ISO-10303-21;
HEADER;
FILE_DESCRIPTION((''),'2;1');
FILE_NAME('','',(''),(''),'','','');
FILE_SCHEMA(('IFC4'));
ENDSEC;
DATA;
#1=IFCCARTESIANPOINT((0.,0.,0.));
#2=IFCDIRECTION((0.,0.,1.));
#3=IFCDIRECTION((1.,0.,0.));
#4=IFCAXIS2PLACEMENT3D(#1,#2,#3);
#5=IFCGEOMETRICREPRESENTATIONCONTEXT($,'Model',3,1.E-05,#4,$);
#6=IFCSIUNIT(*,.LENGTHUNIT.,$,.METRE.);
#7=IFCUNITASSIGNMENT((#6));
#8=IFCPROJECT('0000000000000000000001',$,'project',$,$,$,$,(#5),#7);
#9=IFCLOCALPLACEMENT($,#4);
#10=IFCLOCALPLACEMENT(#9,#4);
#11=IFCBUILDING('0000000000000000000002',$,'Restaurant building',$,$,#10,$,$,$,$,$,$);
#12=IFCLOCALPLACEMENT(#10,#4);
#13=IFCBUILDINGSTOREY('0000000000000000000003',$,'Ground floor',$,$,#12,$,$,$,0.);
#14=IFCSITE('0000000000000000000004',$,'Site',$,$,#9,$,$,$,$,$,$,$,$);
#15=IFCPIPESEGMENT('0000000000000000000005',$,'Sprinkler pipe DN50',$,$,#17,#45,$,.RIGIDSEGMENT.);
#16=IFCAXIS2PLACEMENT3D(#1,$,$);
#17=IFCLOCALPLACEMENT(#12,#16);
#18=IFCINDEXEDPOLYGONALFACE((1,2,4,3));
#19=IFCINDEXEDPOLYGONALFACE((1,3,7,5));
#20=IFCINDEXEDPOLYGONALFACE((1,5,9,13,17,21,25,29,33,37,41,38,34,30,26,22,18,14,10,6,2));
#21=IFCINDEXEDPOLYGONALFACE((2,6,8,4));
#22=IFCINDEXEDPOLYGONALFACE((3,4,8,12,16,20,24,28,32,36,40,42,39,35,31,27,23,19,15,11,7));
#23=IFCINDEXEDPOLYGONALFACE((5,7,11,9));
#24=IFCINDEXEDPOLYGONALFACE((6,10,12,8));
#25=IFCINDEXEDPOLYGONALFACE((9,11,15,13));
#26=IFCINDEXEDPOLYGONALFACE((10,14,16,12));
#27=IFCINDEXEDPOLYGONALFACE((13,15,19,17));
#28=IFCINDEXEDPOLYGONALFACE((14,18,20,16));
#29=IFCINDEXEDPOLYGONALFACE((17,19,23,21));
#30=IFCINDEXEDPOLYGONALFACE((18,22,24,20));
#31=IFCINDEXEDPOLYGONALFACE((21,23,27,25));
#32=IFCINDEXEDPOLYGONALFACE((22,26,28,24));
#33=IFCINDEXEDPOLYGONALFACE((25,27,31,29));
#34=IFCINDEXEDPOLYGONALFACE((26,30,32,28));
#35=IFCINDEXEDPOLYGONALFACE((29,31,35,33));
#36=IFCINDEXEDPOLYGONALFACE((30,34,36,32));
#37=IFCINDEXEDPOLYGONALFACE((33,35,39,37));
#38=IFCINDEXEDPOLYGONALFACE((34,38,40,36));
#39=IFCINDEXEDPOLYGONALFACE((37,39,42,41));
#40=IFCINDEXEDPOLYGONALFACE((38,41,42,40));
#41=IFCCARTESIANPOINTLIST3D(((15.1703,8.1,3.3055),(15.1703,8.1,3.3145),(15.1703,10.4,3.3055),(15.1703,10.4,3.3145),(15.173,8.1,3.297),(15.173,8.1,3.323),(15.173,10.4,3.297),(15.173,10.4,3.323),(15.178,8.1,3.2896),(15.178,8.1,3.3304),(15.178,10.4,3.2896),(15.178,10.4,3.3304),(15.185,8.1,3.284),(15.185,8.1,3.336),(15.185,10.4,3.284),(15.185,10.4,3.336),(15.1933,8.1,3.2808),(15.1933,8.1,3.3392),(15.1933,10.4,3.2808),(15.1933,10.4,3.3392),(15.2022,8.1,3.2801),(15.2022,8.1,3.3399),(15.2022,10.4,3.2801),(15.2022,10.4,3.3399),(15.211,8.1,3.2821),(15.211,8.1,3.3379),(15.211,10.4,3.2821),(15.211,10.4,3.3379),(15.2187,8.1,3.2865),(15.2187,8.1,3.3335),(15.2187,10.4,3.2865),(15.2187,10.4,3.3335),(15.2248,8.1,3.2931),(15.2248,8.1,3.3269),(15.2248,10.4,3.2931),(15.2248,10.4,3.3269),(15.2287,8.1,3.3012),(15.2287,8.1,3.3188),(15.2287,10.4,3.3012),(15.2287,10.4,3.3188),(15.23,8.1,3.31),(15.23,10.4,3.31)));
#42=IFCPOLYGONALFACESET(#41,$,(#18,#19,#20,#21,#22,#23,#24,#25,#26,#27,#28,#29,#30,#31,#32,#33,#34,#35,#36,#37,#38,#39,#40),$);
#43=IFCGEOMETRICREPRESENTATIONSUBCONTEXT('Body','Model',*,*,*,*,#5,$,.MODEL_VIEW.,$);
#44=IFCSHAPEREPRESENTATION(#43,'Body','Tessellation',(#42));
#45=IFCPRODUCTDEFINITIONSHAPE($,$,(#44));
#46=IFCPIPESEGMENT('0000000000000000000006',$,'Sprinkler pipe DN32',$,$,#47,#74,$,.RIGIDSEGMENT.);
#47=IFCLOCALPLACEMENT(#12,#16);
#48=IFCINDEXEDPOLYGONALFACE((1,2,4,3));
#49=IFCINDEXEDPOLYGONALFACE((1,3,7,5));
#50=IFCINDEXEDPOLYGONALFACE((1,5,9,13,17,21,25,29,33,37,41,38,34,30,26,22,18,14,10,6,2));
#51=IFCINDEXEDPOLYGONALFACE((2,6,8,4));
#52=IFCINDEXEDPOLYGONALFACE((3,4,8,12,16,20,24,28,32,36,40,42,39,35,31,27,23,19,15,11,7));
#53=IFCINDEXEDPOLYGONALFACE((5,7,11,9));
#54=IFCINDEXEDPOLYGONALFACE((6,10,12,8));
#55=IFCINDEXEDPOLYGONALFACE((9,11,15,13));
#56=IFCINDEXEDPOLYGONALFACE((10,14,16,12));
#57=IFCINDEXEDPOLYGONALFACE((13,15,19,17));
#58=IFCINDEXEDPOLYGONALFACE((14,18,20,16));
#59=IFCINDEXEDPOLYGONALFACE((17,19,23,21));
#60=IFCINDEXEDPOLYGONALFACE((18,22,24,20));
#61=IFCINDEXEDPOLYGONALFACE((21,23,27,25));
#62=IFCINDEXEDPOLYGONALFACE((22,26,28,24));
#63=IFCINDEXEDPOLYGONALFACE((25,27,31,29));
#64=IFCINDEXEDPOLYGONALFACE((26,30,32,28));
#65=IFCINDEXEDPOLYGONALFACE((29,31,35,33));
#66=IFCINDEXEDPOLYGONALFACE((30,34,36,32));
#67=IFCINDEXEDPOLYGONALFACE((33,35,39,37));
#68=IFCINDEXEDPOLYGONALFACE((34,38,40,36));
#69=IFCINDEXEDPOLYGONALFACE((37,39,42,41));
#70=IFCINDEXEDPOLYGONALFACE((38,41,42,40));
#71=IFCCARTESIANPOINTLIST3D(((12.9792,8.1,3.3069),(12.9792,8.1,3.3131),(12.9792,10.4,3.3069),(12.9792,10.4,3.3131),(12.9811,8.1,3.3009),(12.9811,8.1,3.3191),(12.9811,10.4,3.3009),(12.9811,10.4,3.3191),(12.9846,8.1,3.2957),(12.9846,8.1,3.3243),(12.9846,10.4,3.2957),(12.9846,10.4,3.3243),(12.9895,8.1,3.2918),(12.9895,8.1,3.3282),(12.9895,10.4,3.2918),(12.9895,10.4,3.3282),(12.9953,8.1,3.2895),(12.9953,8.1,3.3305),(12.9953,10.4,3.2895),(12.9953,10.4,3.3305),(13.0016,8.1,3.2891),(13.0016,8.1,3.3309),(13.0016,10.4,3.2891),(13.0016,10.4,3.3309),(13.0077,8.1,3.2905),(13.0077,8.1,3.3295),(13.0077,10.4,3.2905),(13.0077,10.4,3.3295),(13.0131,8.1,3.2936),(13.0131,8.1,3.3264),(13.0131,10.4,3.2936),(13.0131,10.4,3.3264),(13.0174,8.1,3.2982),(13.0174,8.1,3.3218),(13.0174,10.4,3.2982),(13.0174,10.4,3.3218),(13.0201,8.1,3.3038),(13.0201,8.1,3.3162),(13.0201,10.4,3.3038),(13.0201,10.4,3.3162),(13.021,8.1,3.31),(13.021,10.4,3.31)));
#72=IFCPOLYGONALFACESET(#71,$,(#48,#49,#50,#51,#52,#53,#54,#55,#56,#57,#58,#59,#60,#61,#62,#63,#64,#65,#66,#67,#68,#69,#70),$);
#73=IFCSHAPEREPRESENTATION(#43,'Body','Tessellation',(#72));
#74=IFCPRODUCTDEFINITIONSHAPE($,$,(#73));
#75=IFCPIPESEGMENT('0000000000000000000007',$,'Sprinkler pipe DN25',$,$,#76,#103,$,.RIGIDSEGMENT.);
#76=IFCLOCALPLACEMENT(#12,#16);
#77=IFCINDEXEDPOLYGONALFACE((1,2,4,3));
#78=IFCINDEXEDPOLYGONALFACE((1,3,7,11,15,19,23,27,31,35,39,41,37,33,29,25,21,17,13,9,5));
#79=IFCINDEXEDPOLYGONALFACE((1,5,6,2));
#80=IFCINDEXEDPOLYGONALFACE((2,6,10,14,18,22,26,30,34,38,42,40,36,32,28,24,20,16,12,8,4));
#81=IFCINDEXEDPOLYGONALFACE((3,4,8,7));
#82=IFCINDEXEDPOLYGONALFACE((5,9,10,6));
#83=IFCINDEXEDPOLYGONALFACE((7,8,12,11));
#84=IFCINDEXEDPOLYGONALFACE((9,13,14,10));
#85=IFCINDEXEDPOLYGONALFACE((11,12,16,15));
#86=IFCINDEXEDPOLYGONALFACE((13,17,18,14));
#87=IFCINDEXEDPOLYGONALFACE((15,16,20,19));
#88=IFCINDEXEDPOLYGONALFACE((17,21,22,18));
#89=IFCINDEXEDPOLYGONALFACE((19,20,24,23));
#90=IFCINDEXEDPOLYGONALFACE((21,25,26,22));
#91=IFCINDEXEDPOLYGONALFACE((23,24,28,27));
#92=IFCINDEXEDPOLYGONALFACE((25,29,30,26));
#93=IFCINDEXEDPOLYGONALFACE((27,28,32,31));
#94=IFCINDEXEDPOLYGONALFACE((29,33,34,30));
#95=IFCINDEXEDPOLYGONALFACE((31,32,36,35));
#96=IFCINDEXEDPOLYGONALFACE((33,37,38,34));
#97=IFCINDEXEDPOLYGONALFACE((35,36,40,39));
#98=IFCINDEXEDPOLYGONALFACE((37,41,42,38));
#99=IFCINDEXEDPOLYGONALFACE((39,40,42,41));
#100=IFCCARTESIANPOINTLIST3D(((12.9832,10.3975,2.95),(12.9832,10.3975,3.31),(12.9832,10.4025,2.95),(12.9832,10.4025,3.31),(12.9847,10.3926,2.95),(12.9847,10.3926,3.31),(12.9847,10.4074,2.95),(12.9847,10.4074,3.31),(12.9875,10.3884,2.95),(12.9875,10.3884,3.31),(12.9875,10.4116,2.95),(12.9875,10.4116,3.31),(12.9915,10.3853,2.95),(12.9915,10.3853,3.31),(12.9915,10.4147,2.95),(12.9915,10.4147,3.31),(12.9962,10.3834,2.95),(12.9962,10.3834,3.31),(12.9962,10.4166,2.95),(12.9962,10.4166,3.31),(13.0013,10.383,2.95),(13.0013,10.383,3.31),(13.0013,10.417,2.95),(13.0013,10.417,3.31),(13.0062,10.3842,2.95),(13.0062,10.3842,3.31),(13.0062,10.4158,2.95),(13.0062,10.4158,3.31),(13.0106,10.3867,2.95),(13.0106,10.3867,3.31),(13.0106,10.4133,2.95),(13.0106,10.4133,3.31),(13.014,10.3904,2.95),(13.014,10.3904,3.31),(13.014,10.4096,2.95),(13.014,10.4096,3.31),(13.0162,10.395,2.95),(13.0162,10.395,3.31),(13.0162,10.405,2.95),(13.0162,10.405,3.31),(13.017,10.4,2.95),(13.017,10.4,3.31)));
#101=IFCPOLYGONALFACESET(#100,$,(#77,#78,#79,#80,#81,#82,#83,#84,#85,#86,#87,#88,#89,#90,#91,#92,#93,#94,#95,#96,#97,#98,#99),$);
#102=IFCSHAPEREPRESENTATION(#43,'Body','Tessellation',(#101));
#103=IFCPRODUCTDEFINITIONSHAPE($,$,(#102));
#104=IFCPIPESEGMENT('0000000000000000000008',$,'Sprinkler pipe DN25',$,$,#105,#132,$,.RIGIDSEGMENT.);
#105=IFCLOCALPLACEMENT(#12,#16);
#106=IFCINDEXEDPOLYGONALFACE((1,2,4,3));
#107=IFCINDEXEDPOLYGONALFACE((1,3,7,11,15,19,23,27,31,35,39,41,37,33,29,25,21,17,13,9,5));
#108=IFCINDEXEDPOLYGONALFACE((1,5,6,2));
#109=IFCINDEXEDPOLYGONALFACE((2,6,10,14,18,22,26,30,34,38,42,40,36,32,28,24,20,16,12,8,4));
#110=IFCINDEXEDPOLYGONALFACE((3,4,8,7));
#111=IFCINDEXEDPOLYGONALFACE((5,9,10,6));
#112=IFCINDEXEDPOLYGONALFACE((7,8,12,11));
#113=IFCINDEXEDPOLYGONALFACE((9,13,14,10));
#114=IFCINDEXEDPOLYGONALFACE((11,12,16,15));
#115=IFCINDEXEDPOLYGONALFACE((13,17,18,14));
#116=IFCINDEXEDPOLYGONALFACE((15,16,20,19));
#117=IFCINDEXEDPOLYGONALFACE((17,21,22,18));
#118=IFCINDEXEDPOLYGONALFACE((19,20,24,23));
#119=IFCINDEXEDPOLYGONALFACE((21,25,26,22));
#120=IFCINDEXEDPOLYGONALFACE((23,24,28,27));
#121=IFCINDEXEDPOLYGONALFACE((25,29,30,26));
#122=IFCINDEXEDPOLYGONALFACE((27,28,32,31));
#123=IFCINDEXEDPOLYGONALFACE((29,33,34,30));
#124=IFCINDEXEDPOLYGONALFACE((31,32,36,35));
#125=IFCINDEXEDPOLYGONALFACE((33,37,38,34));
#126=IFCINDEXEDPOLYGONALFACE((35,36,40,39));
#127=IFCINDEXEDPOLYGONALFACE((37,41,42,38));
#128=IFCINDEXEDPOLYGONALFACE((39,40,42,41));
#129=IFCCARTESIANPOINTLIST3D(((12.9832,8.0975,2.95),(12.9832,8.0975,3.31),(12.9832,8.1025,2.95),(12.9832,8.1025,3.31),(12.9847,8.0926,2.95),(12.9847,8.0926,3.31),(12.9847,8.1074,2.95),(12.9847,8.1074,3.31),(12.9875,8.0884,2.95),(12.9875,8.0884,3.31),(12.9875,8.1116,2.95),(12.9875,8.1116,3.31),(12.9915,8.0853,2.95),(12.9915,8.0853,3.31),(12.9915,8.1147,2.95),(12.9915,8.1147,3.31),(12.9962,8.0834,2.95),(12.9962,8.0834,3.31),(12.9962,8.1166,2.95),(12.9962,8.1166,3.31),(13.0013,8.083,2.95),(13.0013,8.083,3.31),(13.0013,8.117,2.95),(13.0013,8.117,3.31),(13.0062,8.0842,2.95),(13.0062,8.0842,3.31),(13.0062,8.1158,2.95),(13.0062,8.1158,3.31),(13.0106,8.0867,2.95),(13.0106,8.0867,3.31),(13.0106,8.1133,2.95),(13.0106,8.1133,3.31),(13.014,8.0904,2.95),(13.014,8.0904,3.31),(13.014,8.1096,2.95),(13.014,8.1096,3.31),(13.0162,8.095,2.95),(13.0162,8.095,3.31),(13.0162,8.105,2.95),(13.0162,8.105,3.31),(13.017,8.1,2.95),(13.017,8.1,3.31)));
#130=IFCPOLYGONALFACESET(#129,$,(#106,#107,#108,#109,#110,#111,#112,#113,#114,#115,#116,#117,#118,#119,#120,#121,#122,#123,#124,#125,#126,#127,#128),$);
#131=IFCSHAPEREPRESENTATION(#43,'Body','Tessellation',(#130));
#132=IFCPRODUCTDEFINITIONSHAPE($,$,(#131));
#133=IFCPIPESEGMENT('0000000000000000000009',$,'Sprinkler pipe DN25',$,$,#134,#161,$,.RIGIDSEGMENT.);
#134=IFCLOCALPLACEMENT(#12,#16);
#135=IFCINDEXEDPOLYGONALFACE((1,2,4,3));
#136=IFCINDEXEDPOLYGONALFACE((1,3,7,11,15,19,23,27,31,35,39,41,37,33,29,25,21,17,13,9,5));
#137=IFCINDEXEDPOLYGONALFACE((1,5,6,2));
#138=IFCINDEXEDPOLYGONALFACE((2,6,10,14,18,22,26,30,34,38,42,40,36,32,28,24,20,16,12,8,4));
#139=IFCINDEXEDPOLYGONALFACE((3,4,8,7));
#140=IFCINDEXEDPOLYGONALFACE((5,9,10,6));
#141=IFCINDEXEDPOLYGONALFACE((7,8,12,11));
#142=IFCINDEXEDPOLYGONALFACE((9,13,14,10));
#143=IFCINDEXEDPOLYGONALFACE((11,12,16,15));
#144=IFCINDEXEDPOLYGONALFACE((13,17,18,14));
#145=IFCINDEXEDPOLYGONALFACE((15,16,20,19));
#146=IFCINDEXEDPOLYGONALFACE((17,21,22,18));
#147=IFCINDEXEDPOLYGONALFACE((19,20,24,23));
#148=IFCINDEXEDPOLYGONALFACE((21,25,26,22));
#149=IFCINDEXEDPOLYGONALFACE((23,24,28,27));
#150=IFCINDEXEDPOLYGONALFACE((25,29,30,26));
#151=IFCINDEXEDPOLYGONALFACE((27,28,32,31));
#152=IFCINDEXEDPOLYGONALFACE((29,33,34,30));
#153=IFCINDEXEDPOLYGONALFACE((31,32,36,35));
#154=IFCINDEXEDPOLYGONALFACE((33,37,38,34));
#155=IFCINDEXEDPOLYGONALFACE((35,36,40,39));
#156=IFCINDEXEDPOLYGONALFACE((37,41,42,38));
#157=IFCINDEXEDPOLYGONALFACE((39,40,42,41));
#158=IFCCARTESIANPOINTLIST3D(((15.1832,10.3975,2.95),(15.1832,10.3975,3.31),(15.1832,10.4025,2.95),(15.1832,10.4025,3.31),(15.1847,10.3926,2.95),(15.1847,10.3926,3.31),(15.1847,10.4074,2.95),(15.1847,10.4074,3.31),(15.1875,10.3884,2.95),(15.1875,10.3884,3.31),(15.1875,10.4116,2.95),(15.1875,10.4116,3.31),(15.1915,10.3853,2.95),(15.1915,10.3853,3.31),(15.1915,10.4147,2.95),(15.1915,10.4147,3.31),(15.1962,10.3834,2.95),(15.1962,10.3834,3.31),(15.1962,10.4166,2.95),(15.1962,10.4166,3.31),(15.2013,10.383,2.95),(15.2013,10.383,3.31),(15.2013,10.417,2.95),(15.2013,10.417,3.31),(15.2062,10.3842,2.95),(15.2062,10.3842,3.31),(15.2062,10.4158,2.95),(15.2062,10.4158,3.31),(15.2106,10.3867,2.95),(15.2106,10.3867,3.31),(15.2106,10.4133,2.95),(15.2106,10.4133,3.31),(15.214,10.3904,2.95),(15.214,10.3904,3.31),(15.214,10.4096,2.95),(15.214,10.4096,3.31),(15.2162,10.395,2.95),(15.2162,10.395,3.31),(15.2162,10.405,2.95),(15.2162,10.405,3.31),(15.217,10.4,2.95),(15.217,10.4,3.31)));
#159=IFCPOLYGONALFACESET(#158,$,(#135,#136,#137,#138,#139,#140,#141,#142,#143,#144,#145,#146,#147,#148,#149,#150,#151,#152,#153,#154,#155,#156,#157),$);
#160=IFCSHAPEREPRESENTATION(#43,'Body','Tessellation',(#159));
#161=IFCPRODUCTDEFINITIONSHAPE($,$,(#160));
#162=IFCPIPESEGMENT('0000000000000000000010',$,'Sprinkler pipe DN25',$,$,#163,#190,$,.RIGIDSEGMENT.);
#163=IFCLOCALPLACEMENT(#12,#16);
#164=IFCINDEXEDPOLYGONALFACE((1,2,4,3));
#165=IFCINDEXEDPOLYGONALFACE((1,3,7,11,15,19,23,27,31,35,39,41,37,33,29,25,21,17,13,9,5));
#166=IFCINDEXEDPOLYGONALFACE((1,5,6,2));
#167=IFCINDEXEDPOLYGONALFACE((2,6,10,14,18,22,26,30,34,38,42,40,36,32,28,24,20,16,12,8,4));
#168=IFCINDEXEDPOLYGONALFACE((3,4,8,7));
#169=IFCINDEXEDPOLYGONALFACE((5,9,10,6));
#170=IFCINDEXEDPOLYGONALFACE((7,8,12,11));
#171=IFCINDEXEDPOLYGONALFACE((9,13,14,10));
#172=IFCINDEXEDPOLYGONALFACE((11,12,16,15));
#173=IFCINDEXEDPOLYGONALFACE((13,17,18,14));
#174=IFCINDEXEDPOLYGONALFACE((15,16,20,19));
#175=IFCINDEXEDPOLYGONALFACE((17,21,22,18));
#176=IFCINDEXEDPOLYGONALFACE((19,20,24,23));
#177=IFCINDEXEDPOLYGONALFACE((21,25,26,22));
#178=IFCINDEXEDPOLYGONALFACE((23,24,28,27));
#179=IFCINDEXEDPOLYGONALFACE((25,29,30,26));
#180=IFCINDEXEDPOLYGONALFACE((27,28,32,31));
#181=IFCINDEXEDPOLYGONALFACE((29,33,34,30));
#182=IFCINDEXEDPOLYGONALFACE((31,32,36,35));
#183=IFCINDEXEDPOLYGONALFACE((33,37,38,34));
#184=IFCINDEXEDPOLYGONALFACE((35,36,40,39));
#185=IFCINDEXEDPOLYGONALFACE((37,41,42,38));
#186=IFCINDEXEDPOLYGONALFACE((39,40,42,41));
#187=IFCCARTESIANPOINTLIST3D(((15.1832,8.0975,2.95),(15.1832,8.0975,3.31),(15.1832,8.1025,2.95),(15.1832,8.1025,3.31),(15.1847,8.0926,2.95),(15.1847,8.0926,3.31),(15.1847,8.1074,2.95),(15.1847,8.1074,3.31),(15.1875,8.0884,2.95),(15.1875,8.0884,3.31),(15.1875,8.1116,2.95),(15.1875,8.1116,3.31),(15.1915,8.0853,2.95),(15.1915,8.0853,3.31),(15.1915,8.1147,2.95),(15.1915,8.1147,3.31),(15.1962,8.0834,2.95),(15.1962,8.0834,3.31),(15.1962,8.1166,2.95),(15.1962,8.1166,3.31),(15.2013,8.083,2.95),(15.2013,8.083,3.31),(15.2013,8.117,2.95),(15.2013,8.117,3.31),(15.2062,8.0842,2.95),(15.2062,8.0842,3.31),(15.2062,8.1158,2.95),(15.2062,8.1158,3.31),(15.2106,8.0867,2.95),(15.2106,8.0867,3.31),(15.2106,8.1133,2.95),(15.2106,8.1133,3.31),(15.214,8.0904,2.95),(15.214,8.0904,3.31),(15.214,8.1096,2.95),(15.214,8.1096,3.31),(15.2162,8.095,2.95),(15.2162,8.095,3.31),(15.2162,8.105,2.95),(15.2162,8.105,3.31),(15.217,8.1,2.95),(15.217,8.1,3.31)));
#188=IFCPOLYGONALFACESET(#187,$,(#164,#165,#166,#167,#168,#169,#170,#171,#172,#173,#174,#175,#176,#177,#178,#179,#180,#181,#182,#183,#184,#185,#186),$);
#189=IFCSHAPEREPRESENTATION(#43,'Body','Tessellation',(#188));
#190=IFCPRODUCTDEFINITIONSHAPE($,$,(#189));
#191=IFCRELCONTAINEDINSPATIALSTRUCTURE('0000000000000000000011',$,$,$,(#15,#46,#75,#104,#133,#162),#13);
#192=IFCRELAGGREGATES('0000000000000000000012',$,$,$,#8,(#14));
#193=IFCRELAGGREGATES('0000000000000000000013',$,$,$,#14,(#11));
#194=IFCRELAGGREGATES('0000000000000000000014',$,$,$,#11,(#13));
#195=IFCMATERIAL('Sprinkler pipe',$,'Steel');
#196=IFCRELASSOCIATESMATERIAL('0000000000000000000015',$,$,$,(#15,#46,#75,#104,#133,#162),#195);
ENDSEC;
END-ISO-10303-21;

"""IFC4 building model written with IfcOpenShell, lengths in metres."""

from ifc_helpers import new_model, si_unit, frame, origin_with_axes, origin_2d, place, context, subcontext, project, spatial, circle, extrude, material, element, save


model = new_model("IFC4")

# Units and contexts
model_context = context("Model", 3, precision=1e-05, world=origin_with_axes())
body_context = subcontext(model_context, "Body", "Model", "MODEL_VIEW")
ifc_project = project(units=[si_unit("LENGTHUNIT", "METRE")], contexts=[model_context])

# Site, building, storey
site_placement = place(None, origin_with_axes())
site = spatial("IfcSite", under=ifc_project, at=site_placement, Name="Site")
building_placement = place(site_placement, origin_with_axes())
building = spatial("IfcBuilding", under=site, at=building_placement, Name="Restaurant building")
storey_placement = place(building_placement, origin_with_axes())
storey = spatial("IfcBuildingStorey", under=building, at=storey_placement, Name="Ground floor", Elevation=0.0)

# Pipe segments
ifc_material_1 = material(Name="Sprinkler pipe", Category="Steel")
pipe_segment_1_placement = place(storey_placement, frame((15.2, 10.4, 3.31)))
element("IfcPipeSegment", 1, at=pipe_segment_1_placement, inside=storey, material=ifc_material_1, Name="Sprinkler pipe DN50", PredefinedType="RIGIDSEGMENT", context=body_context, shape_type="SweptSolid", body=[
    extrude(circle(Radius=0.03, at=origin_2d()), frame((0.0, 0.0, 0.0), z_axis=(0.0, -1.0, 0.0), x_axis=(1.0, 0.0, 0.0)), (0.0, 0.0, 1.0), 2.3),
])
pipe_segment_2_placement = place(storey_placement, frame((13.0, 10.4, 3.31)))
element("IfcPipeSegment", 2, at=pipe_segment_2_placement, inside=storey, material=ifc_material_1, Name="Sprinkler pipe DN32", PredefinedType="RIGIDSEGMENT", context=body_context, shape_type="SweptSolid", body=[
    extrude(circle(Radius=0.021, at=origin_2d()), frame((0.0, 0.0, 0.0), z_axis=(0.0, -1.0, 0.0), x_axis=(1.0, 0.0, 0.0)), (0.0, 0.0, 1.0), 2.3),
])
for number, where, name in (
    (3, (13.0, 10.4, 3.31), "Sprinkler pipe DN25"),
    (4, (13.0, 8.1, 3.31), "Sprinkler pipe DN25"),
    (5, (15.2, 10.4, 3.31), "Sprinkler pipe DN25"),
    (6, (15.2, 8.1, 3.31), "Sprinkler pipe DN25"),
):
    element("IfcPipeSegment", number, at=place(storey_placement, frame(where)), inside=storey, material=ifc_material_1, Name=name, PredefinedType="RIGIDSEGMENT", context=body_context, shape_type="SweptSolid", body=[
        extrude(circle(Radius=0.017, at=origin_2d()), frame((0.0, 0.0, 0.0), z_axis=(0.0, 0.0, -1.0), x_axis=(1.0, 0.0, 0.0)), (0.0, 0.0, 1.0), 0.36),
    ])

save(model, "model.ifc")
